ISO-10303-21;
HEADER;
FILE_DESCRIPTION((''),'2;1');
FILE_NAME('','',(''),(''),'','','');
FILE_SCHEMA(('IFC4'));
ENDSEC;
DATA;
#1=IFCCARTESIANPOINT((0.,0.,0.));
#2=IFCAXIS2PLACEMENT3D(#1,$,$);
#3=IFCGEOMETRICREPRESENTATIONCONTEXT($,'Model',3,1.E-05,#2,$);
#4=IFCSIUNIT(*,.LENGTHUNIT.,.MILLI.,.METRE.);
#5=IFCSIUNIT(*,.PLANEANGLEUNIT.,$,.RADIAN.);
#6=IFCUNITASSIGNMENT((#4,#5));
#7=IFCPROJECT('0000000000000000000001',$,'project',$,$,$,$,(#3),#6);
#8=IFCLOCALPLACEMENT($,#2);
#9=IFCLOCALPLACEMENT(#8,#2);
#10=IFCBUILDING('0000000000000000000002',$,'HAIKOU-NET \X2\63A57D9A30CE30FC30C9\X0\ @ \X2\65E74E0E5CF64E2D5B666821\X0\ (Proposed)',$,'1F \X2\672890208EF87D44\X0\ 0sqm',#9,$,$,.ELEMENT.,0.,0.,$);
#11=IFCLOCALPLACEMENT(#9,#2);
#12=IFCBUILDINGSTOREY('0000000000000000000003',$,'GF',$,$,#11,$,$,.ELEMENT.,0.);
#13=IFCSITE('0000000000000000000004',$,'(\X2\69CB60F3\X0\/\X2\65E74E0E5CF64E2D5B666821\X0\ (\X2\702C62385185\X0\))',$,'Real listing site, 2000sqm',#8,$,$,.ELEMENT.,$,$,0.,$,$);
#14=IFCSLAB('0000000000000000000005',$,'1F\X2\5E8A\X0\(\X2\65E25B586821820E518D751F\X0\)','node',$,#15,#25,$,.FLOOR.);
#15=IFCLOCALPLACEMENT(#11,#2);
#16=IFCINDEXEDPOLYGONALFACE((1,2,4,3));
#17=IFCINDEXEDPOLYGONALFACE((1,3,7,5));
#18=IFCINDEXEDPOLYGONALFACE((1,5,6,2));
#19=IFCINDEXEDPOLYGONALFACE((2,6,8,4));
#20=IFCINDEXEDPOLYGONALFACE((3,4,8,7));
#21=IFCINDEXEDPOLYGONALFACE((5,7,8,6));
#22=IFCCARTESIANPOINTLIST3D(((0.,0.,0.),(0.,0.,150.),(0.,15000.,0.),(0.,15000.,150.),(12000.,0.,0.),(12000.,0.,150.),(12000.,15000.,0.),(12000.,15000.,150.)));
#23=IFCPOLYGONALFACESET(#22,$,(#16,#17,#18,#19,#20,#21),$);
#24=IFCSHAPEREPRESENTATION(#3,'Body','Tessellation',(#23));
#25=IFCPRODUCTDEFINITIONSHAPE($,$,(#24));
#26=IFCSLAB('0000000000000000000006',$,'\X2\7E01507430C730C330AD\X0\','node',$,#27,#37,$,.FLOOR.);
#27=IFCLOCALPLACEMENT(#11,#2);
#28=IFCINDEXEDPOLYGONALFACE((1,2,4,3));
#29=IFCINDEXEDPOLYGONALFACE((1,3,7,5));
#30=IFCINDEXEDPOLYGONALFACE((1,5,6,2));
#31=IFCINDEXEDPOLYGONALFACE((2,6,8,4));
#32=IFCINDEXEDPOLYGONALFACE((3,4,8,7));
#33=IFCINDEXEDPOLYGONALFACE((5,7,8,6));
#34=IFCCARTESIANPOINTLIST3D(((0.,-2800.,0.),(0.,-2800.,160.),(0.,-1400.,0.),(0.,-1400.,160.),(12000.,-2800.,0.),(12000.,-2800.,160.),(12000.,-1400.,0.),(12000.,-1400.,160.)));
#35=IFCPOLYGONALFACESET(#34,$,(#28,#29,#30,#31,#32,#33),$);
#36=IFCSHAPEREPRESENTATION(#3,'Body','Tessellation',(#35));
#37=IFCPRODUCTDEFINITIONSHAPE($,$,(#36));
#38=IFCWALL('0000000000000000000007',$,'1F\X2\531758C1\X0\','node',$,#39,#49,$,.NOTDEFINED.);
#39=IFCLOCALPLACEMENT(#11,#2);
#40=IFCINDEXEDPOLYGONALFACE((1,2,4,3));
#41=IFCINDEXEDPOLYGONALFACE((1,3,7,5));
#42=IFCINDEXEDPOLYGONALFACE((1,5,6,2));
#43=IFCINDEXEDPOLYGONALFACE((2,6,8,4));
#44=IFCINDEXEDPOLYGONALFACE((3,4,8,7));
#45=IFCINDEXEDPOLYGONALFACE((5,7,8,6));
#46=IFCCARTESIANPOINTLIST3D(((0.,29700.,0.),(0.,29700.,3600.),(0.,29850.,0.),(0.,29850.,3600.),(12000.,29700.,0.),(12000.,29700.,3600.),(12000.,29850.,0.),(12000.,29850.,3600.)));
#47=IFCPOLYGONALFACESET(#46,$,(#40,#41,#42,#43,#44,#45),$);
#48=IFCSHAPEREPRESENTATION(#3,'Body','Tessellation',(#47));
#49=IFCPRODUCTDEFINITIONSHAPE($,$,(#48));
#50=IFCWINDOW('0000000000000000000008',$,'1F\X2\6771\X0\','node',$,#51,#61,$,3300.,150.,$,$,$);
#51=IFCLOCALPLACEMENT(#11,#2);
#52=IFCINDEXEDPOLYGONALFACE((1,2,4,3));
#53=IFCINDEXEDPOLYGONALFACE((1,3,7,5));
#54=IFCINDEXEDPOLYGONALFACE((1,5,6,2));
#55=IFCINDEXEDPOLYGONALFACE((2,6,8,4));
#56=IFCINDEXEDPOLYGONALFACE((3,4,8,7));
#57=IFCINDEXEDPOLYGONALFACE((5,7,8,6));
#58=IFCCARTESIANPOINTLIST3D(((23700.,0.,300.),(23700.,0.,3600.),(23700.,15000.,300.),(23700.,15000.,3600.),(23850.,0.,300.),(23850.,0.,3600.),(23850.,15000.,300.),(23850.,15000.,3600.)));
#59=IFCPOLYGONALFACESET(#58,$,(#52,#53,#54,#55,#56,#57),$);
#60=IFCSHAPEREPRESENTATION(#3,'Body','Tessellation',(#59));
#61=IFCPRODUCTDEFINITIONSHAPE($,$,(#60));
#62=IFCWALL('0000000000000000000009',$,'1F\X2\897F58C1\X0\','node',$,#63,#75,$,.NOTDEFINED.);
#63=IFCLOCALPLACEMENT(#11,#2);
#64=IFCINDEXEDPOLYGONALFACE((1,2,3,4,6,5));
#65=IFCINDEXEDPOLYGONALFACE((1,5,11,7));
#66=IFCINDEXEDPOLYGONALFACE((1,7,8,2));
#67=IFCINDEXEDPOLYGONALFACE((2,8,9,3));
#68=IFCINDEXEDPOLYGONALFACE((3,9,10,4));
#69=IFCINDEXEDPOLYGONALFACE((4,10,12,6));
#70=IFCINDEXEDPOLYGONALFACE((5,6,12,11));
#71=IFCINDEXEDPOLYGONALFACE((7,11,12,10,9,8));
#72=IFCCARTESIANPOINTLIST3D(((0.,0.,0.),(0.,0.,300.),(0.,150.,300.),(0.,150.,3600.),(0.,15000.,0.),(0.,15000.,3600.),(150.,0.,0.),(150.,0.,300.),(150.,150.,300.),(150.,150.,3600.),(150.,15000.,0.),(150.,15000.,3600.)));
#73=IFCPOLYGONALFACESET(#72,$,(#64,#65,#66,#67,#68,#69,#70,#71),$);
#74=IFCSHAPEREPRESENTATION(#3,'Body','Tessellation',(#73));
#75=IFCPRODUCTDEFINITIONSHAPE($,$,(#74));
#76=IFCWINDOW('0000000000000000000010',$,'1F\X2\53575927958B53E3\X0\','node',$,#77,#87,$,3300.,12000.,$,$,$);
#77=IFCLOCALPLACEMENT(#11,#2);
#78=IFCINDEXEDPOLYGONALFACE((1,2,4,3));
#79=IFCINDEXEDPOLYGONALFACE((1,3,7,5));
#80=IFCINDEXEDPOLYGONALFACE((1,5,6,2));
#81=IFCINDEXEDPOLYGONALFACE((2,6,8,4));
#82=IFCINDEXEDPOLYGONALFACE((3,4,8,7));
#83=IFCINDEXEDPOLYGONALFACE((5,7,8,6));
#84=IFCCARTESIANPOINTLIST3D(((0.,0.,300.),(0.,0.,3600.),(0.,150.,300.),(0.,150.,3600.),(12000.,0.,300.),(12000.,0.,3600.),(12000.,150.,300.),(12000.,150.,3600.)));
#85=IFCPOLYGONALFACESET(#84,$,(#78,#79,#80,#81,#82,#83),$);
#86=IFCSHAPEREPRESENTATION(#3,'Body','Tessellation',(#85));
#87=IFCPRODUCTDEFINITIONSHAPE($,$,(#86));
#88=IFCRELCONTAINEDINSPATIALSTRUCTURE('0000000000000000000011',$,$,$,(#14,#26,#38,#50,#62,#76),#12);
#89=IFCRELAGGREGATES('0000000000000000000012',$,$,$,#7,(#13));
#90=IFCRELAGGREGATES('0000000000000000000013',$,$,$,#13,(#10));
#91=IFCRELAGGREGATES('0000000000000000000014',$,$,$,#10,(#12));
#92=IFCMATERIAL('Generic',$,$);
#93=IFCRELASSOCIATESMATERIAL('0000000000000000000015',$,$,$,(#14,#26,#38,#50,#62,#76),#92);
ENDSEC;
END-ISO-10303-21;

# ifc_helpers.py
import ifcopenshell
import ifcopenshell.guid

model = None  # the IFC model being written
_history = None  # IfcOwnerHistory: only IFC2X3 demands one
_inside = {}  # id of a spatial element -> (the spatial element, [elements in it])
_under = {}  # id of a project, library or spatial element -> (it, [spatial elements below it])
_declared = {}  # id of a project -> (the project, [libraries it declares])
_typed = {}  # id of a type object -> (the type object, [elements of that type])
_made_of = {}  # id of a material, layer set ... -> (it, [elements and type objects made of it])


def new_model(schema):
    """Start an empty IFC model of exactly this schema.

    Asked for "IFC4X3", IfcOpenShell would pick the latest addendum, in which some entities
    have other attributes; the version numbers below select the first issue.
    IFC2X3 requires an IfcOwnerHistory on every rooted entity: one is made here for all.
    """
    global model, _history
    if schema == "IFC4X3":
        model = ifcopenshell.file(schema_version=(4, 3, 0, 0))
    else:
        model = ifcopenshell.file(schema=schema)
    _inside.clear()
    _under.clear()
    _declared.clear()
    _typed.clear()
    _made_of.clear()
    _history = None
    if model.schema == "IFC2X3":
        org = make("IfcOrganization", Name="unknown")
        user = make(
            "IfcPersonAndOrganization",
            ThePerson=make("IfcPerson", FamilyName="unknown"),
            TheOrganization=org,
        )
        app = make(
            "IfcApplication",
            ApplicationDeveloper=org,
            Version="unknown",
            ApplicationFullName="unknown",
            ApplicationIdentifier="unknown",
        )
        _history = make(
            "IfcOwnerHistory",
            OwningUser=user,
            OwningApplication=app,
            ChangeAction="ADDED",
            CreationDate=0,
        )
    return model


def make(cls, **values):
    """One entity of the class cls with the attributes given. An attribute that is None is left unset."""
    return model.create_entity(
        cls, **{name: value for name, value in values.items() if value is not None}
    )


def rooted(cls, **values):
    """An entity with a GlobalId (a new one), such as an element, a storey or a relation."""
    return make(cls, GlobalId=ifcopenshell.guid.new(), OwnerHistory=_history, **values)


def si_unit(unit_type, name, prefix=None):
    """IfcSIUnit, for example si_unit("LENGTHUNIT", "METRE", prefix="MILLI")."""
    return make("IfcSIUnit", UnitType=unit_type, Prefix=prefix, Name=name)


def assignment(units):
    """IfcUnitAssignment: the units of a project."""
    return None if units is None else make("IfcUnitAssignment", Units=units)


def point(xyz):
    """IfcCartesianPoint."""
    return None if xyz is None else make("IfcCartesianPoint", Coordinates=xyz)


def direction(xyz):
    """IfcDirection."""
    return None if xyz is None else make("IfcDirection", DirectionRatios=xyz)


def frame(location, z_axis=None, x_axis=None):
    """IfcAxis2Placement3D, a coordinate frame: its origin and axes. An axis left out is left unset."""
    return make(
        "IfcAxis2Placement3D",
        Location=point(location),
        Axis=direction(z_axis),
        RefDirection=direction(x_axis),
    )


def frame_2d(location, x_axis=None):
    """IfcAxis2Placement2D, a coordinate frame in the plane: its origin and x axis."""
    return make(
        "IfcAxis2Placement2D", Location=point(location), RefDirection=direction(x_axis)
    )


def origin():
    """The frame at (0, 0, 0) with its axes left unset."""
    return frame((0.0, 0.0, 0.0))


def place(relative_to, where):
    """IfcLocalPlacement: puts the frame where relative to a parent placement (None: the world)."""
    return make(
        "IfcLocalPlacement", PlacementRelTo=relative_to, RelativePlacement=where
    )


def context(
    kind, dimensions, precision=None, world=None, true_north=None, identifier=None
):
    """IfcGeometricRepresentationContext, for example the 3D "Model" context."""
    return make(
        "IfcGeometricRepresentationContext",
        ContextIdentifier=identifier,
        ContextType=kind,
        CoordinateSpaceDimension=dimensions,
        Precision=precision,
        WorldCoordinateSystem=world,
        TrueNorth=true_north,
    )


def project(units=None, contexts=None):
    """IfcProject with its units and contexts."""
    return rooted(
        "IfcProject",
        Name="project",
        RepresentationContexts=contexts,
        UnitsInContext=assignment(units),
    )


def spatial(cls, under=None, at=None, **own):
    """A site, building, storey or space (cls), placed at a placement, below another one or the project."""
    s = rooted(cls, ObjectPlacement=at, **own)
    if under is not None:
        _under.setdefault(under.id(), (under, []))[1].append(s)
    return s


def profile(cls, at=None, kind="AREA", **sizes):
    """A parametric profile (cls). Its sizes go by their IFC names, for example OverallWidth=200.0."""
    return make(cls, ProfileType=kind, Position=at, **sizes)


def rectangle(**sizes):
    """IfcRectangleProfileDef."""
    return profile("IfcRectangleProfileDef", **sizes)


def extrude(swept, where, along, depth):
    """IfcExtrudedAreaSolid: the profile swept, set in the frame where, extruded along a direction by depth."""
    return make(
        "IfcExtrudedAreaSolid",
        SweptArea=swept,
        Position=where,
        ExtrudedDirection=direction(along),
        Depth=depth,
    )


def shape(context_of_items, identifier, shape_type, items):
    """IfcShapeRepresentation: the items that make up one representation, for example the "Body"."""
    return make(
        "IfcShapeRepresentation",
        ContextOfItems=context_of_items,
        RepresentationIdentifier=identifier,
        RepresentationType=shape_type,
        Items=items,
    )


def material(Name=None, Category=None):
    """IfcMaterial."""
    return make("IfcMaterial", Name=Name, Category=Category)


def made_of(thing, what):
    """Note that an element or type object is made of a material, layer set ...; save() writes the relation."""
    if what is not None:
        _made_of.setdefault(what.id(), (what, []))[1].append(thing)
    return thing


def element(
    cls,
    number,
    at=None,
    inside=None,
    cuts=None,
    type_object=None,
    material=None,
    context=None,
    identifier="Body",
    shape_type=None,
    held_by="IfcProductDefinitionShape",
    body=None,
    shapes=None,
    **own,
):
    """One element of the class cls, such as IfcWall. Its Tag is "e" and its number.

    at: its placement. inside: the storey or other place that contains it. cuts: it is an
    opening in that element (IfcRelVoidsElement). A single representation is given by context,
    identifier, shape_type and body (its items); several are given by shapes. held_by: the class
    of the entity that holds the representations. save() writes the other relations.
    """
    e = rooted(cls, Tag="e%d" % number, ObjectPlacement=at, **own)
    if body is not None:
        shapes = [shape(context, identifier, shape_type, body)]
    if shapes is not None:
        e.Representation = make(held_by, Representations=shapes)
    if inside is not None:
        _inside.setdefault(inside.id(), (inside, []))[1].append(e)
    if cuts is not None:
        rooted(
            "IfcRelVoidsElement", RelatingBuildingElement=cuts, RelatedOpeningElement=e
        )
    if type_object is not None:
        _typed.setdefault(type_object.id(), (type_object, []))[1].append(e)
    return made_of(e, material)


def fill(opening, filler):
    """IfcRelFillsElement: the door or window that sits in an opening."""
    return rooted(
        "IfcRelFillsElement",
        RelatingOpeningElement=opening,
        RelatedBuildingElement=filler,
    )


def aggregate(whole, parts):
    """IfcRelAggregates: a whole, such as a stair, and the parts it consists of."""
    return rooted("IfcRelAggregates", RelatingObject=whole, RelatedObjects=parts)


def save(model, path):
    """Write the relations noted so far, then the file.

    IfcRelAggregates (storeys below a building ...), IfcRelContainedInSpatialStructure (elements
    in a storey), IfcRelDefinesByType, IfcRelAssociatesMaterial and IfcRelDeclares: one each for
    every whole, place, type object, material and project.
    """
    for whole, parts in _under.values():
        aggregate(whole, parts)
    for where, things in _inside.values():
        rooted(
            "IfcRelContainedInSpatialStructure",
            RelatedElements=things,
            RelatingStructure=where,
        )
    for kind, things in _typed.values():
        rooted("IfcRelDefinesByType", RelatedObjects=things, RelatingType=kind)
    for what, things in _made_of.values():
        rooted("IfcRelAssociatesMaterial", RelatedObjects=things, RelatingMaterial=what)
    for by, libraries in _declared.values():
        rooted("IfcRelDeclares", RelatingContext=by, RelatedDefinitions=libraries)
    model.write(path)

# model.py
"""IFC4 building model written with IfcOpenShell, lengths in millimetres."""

from ifc_helpers import new_model, si_unit, frame, frame_2d, origin, place, context, project, spatial, rectangle, extrude, material, element, fill, save


model = new_model("IFC4")

# Units and contexts
model_context = context("Model", 3, precision=1e-05, world=origin())
ifc_project = project(units=[si_unit("LENGTHUNIT", "METRE", prefix="MILLI"), si_unit("PLANEANGLEUNIT", "RADIAN")], contexts=[model_context])

# Site, building, storey
site_placement = place(None, origin())
site = spatial("IfcSite", under=ifc_project, at=site_placement, Name="(構想/旧与島中学校 (瀬戸内))", ObjectType="Real listing site, 2000sqm", CompositionType="ELEMENT", RefElevation=0.0)
building_placement = place(site_placement, origin())
building = spatial("IfcBuilding", under=site, at=building_placement, Name="HAIKOU-NET 接続ノード @ 旧与島中学校 (Proposed)", ObjectType="1F 木造軸組 0sqm", CompositionType="ELEMENT", ElevationOfRefHeight=0.0, ElevationOfTerrain=0.0)
storey_placement = place(building_placement, origin())
storey = spatial("IfcBuildingStorey", under=building, at=storey_placement, Name="GF", CompositionType="ELEMENT", Elevation=0.0)

# Slabs
ifc_material = material(Name="Generic")
slab_1_placement = place(storey_placement, origin())
element("IfcSlab", 1, at=slab_1_placement, inside=storey, material=ifc_material, Name="1F床(既存校舎再生)", Description="node", PredefinedType="FLOOR", context=model_context, shape_type="SweptSolid", body=[
    extrude(rectangle(XDim=12000.0, YDim=15000.0, at=frame_2d((6000.0, 7500.0))), origin(), (0.0, 0.0, 1.0), 150.0),
])
slab_2_placement = place(storey_placement, frame((0.0, -1400.0, 0.0)))
element("IfcSlab", 2, at=slab_2_placement, inside=storey, material=ifc_material, Name="縁側デッキ", Description="node", PredefinedType="FLOOR", context=model_context, shape_type="SweptSolid", body=[
    extrude(rectangle(XDim=12000.0, YDim=1400.0, at=frame_2d((6000.0, 700.0))), frame((0.0, -1400.0, 0.0)), (0.0, 0.0, 1.0), 160.0),
])

# Walls, openings, windows
wall_1_placement = place(storey_placement, frame((0.0, 14850.0, 0.0)))
wall_1 = element("IfcWall", 3, at=wall_1_placement, inside=storey, material=ifc_material, Name="1F北壁", Description="node", PredefinedType="NOTDEFINED", context=model_context, shape_type="SweptSolid", body=[
    extrude(rectangle(XDim=12000.0, YDim=150.0, at=frame_2d((6000.0, 75.0))), frame((0.0, 14850.0, 0.0)), (0.0, 0.0, 1.0), 3600.0),
])
opening_1_placement = place(storey_placement, frame((11850.0, 0.0, 150.0)))
opening_1 = element("IfcOpeningElement", 4, at=opening_1_placement, cuts=wall_1, PredefinedType="NOTDEFINED", context=model_context, shape_type="SweptSolid", body=[
    extrude(rectangle(XDim=150.0, YDim=15000.0, at=frame_2d((75.0, 7500.0))), frame((11850.0, 0.0, 150.0)), (0.0, 0.0, 1.0), 3300.0),
])
window_1_placement = place(storey_placement, frame((11850.0, 0.0, 150.0)))
window_1 = element("IfcWindow", 5, at=window_1_placement, inside=storey, material=ifc_material, Name="1F東", Description="node", OverallHeight=3300.0, OverallWidth=150.0, context=model_context, shape_type="SweptSolid", body=[
    extrude(rectangle(XDim=150.0, YDim=15000.0, at=frame_2d((75.0, 7500.0))), frame((11850.0, 0.0, 150.0)), (0.0, 0.0, 1.0), 3300.0),
])
fill(opening_1, window_1)
wall_2_placement = place(storey_placement, origin())
wall_2 = element("IfcWall", 6, at=wall_2_placement, inside=storey, material=ifc_material, Name="1F西壁", Description="node", PredefinedType="NOTDEFINED", context=model_context, shape_type="SweptSolid", body=[
    extrude(rectangle(XDim=150.0, YDim=15000.0, at=frame_2d((75.0, 7500.0))), origin(), (0.0, 0.0, 1.0), 3600.0),
])
opening_2_placement = place(storey_placement, frame((0.0, 0.0, 150.0)))
opening_2 = element("IfcOpeningElement", 7, at=opening_2_placement, cuts=wall_2, PredefinedType="NOTDEFINED", context=model_context, shape_type="SweptSolid", body=[
    extrude(rectangle(XDim=12000.0, YDim=150.0, at=frame_2d((6000.0, 75.0))), frame((0.0, 0.0, 150.0)), (0.0, 0.0, 1.0), 3300.0),
])
window_2_placement = place(storey_placement, frame((0.0, 0.0, 150.0)))
window_2 = element("IfcWindow", 8, at=window_2_placement, inside=storey, material=ifc_material, Name="1F南大開口", Description="node", OverallHeight=3300.0, OverallWidth=12000.0, context=model_context, shape_type="SweptSolid", body=[
    extrude(rectangle(XDim=12000.0, YDim=150.0, at=frame_2d((6000.0, 75.0))), frame((0.0, 0.0, 150.0)), (0.0, 0.0, 1.0), 3300.0),
])
fill(opening_2, window_2)

save(model, "model.ifc")
